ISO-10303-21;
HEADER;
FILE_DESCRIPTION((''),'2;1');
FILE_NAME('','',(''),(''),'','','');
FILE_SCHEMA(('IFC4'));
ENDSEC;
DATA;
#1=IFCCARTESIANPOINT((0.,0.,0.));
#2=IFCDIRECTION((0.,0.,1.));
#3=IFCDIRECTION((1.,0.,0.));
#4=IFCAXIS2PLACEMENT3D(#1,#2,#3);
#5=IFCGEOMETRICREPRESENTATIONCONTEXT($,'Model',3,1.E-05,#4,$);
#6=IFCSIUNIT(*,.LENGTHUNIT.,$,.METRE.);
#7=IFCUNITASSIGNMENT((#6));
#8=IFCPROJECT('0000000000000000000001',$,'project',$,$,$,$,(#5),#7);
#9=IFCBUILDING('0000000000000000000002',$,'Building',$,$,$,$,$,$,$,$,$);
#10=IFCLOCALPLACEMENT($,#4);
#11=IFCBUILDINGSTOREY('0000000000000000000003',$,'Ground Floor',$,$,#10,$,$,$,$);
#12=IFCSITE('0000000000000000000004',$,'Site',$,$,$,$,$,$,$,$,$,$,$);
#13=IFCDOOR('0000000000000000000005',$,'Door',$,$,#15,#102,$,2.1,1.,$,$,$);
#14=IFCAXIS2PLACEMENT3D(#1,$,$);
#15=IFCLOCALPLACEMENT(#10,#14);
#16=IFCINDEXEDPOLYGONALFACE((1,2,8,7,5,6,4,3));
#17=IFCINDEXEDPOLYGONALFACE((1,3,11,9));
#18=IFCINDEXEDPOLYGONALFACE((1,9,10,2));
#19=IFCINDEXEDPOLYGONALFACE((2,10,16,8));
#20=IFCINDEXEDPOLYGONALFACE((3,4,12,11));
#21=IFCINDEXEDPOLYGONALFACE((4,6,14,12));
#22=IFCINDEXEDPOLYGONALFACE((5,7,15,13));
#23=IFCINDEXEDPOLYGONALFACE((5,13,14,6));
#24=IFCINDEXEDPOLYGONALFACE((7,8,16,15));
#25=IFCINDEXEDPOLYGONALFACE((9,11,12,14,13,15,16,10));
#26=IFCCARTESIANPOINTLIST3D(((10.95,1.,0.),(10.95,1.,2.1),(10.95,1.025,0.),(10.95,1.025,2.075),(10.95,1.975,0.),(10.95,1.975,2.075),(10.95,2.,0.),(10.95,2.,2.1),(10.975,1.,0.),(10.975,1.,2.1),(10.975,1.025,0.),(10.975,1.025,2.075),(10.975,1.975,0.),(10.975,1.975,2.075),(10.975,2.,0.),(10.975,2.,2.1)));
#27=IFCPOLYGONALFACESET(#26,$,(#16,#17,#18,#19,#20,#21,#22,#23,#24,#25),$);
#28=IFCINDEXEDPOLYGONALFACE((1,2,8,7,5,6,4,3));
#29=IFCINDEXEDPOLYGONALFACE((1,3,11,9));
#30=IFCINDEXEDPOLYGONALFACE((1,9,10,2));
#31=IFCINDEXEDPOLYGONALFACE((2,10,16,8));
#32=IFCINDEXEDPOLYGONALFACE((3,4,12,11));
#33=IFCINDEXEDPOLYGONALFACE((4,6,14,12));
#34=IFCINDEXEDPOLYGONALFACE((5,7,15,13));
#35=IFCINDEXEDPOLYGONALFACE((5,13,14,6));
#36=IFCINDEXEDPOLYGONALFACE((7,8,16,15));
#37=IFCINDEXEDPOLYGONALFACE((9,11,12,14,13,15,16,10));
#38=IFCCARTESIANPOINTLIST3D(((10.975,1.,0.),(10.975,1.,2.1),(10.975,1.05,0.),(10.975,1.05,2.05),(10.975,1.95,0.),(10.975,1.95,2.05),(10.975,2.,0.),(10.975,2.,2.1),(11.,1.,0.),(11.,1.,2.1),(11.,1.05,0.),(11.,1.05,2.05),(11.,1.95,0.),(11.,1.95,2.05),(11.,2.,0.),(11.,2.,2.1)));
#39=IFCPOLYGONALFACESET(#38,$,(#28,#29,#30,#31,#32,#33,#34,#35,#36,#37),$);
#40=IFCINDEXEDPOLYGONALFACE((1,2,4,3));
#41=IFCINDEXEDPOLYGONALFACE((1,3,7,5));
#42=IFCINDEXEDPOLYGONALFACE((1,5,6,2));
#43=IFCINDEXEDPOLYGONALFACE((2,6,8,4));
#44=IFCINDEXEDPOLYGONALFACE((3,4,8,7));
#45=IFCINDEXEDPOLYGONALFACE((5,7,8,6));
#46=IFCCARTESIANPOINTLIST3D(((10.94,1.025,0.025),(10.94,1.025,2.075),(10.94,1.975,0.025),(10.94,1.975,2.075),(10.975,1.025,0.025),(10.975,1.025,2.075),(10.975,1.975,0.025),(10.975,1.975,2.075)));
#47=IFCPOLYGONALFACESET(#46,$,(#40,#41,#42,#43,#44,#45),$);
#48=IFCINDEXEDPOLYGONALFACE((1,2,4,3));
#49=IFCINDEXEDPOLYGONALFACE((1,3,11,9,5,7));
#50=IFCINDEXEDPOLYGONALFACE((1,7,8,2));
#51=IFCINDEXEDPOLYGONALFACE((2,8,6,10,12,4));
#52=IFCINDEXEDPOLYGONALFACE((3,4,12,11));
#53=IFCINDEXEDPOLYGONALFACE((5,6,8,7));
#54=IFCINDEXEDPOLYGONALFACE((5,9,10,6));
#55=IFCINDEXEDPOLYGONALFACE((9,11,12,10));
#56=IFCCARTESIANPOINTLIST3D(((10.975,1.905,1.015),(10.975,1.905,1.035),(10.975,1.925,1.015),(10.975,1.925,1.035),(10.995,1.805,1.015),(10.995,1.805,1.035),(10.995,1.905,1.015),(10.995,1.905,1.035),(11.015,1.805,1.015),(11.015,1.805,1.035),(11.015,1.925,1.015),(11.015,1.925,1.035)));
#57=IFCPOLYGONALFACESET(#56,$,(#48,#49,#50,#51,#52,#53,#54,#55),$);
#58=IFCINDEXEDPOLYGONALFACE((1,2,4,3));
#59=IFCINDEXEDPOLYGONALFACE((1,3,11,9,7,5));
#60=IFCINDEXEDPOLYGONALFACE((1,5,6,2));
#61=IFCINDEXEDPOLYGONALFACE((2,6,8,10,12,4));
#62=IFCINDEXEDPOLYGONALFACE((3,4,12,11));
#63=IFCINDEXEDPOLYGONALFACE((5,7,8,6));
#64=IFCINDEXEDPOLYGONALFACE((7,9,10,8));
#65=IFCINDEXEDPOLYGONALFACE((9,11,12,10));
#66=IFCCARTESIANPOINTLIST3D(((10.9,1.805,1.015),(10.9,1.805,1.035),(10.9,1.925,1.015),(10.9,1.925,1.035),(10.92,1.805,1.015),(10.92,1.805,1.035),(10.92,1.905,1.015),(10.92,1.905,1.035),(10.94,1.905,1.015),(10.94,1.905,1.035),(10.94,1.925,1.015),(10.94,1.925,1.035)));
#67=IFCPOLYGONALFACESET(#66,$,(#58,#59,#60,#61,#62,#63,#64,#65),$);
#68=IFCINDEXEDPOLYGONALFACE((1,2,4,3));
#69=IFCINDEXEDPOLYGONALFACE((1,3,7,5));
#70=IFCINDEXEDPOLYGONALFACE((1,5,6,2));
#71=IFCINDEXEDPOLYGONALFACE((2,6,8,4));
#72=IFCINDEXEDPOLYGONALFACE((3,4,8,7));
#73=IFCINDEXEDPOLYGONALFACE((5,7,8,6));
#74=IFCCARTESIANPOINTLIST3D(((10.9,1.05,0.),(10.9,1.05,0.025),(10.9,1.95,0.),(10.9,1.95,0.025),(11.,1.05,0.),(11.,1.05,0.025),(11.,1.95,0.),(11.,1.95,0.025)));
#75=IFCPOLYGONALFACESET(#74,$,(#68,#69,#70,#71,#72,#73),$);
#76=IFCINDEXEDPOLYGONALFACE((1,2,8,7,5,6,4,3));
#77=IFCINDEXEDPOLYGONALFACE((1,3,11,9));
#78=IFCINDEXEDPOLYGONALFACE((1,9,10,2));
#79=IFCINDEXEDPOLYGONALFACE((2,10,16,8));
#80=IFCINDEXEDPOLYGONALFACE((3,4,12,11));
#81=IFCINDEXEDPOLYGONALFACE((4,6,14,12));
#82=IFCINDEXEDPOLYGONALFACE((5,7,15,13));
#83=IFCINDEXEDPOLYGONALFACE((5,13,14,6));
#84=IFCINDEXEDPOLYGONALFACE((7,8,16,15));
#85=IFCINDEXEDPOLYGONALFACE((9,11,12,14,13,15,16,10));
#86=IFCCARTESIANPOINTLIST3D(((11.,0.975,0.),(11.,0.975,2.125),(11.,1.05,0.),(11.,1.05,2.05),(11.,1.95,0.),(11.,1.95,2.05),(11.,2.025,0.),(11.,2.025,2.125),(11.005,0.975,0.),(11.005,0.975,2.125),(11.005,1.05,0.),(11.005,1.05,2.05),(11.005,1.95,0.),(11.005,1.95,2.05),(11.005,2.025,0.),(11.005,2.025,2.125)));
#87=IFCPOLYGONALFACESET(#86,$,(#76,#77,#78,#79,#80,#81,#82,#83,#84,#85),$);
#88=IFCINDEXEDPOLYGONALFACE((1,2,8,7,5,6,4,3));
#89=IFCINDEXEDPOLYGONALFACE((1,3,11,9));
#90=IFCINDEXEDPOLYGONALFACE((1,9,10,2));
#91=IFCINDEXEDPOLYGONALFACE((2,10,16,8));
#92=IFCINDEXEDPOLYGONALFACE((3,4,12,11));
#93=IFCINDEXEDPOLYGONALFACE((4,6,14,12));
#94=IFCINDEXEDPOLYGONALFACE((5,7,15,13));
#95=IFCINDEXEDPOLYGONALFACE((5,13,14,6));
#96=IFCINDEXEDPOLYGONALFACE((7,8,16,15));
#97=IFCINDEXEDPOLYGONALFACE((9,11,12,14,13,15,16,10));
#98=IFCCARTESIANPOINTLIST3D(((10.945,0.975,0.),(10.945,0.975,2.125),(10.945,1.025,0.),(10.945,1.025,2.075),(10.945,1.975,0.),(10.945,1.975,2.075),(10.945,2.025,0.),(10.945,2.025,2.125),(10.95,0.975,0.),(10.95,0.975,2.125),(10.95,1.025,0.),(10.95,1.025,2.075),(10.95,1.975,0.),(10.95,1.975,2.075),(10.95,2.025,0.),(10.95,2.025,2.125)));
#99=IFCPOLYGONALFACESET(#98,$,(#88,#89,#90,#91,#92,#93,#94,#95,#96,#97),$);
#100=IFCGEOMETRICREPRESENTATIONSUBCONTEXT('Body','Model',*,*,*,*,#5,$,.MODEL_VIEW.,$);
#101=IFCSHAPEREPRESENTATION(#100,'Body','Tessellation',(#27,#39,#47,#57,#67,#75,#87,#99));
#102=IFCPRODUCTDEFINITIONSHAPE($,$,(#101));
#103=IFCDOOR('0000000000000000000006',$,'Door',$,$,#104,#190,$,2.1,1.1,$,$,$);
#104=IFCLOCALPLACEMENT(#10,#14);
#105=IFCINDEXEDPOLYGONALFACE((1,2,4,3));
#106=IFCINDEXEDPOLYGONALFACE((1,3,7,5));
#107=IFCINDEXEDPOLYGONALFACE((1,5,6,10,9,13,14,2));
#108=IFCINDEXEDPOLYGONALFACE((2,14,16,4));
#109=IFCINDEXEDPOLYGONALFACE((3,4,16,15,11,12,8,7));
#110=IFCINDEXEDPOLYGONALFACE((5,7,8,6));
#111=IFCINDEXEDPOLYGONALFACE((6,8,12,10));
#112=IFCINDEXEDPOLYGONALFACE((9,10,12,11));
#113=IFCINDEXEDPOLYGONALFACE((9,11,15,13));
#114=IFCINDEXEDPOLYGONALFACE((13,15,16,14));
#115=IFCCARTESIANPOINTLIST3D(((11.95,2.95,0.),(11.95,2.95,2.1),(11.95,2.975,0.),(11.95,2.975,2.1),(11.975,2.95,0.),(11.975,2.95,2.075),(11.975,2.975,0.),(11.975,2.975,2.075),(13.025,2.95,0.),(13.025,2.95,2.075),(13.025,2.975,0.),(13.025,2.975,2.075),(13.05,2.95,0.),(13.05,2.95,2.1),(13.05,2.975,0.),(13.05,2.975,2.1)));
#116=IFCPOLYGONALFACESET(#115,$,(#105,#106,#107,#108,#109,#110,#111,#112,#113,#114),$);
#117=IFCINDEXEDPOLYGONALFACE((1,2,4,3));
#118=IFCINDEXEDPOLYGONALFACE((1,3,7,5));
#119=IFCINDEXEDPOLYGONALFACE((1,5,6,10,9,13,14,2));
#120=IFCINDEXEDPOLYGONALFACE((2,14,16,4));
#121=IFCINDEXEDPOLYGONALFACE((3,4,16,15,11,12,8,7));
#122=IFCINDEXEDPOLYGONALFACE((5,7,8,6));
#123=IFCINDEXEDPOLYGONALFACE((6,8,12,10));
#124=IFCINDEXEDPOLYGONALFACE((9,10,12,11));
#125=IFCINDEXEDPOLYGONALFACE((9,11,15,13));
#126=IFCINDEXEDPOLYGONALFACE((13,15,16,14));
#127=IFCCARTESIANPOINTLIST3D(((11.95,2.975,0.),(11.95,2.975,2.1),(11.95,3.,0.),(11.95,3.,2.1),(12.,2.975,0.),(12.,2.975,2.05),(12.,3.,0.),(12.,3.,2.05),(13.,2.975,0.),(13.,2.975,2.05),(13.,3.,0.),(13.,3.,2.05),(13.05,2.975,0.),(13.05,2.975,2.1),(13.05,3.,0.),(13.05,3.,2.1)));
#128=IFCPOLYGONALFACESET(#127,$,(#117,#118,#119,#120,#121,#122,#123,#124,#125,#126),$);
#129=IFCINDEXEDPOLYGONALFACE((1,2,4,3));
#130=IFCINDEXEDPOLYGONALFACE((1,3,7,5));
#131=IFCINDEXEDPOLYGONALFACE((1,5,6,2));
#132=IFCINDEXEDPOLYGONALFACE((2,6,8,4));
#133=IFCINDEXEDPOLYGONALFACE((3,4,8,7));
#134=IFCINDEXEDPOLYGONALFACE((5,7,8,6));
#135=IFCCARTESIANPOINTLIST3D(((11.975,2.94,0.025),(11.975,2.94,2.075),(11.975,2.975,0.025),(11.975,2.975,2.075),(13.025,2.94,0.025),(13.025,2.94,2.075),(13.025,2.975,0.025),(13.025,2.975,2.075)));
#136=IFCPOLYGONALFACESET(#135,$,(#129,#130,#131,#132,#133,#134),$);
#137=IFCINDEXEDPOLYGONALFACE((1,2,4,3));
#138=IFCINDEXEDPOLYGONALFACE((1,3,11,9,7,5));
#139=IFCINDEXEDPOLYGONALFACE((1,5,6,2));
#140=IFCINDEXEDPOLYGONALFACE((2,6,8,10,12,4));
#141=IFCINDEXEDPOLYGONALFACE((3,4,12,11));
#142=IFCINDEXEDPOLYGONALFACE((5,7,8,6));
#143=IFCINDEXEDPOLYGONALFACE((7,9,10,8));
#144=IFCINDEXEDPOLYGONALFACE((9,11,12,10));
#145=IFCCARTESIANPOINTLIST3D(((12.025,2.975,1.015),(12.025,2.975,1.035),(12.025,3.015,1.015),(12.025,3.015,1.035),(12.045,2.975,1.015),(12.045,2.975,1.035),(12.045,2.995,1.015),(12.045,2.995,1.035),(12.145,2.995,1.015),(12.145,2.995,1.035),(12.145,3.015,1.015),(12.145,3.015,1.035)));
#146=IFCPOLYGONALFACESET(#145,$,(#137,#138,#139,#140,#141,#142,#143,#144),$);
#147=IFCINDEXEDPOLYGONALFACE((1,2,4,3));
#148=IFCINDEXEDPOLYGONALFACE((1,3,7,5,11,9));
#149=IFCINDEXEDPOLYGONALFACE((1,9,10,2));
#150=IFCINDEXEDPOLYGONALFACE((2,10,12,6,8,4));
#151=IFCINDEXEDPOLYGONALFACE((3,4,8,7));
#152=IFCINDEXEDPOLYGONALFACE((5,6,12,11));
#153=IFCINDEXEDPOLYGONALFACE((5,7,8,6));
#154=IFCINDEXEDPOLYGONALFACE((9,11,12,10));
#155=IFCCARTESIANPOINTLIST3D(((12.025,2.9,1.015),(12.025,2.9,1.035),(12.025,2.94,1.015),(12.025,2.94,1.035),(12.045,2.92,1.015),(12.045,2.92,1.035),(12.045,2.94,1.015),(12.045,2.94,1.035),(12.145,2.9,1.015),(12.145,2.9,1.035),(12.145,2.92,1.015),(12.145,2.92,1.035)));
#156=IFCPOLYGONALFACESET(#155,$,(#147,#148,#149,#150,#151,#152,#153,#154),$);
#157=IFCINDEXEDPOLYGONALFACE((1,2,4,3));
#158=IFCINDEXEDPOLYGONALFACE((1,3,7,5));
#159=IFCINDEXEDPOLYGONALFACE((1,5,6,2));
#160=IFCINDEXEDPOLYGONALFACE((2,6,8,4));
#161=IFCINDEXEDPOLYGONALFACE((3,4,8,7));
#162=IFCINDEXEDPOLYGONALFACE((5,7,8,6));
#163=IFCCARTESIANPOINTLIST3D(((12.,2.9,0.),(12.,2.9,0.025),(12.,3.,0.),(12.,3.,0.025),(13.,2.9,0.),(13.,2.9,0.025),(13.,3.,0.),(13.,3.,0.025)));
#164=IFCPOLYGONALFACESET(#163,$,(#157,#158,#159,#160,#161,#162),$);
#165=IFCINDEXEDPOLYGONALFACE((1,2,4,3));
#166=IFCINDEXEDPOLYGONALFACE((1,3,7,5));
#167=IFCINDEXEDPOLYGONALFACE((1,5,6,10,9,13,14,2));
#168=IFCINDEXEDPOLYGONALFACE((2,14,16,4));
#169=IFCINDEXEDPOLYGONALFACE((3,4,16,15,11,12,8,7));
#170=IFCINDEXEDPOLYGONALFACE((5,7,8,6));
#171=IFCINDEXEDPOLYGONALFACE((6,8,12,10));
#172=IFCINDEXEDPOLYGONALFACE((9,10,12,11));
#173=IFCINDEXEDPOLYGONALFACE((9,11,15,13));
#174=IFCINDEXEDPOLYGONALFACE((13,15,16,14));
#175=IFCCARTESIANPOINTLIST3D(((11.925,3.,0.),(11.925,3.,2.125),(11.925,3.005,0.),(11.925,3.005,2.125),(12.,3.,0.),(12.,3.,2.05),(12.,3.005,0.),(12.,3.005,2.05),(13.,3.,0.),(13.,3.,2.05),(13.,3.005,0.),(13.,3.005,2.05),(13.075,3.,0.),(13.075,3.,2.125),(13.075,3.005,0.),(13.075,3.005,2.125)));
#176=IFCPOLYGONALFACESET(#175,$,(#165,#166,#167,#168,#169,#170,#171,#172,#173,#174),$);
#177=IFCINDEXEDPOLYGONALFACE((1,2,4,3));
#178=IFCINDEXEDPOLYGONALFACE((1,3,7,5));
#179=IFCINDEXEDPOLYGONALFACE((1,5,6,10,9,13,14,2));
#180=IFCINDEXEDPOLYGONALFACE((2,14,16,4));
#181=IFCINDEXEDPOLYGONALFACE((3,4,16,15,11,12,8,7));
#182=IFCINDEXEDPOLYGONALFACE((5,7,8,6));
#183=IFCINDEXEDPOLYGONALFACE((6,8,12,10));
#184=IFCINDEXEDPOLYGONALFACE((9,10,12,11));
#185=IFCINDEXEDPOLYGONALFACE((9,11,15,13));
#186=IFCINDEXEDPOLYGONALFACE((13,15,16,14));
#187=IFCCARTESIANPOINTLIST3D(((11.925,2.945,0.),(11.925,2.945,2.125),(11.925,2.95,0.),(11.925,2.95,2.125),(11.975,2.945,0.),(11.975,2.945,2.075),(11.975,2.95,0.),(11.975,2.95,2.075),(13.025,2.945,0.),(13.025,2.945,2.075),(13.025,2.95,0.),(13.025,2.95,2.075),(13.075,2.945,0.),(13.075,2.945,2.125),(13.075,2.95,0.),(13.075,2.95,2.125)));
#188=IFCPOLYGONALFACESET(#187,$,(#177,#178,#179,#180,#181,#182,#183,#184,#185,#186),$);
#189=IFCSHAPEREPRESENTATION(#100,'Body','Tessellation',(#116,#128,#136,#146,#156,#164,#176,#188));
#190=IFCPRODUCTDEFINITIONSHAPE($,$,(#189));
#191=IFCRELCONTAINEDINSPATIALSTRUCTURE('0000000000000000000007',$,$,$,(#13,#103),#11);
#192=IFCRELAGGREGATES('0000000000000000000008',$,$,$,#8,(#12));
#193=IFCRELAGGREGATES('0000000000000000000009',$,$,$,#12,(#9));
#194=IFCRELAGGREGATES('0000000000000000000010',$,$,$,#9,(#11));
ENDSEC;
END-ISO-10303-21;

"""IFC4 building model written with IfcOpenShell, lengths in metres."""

from ifc_helpers import new_model, si_unit, frame, origin_with_axes, place, context, subcontext, project, spatial, line, indexed_curve, outline, extrude, element, save


model = new_model("IFC4")

# Units and contexts
model_context = context("Model", 3, precision=1e-05, world=origin_with_axes())
body_context = subcontext(model_context, "Body", "Model", "MODEL_VIEW")
ifc_project = project(units=[si_unit("LENGTHUNIT", "METRE")], contexts=[model_context])

# Site, building, storey
site = spatial("IfcSite", under=ifc_project, Name="Site")
building = spatial("IfcBuilding", under=site, Name="Building")
storey_placement = place(None, origin_with_axes())
storey = spatial("IfcBuildingStorey", under=building, at=storey_placement, Name="Ground Floor")

# Doors
door_1_placement = place(storey_placement, frame((11.0, 1.0, 0.0), z_axis=(0.0, 0.0, 1.0), x_axis=(0.0, 1.0, 0.0)))
element("IfcDoor", 1, at=door_1_placement, inside=storey, Name="Door", OverallHeight=2.1, OverallWidth=1.0, context=body_context, shape_type="SweptSolid", body=[
    extrude(outline(indexed_curve([(0.0, 0.0), (0.0, 2.1), (1.0, 2.1), (1.0, 0.0), (0.975, 0.0), (0.975, 2.075), (0.025, 2.075), (0.025, 0.0)], segments=[line(1, 2, 3, 4, 5, 6, 7, 8, 1)])), frame((0.0, 0.025, 0.0), z_axis=(0.0, -1.0, 0.0), x_axis=(1.0, 0.0, 0.0)), (0.0, 0.0, -1.0), 0.025),
    extrude(outline(indexed_curve([(0.0, 0.0), (0.0, 2.1), (1.0, 2.1), (1.0, 0.0), (0.95, 0.0), (0.95, 2.05), (0.05, 2.05), (0.05, 0.0)], segments=[line(1, 2, 3, 4, 5, 6, 7, 8, 1)])), frame((0.0, 0.0, 0.0), z_axis=(0.0, -1.0, 0.0), x_axis=(1.0, 0.0, 0.0)), (0.0, 0.0, -1.0), 0.025),
    extrude(outline(indexed_curve([(0.0, 0.0), (0.95, 0.0), (0.95, 0.035), (0.0, 0.035)], segments=[line(1, 2, 3, 4, 1)])), frame((0.025, 0.025, 0.025), z_axis=(0.0, 0.0, 1.0), x_axis=(1.0, 0.0, 0.0)), (0.0, 0.0, 1.0), 2.05),
    extrude(outline(indexed_curve([(0.0, 0.0), (0.0, -0.04), (-0.12, -0.04), (-0.12, -0.02), (-0.02, -0.02), (-0.02, 0.0)], segments=[line(1, 2, 3, 4, 5, 6, 1)])), frame((0.925, 0.025, 1.015), z_axis=(0.0, 0.0, 1.0), x_axis=(1.0, 0.0, 0.0)), (0.0, 0.0, 1.0), 0.02),
    extrude(outline(indexed_curve([(0.0, 0.0), (0.0, 0.04), (-0.12, 0.04), (-0.12, 0.02), (-0.02, 0.02), (-0.02, 0.0)], segments=[line(1, 2, 3, 4, 5, 6, 1)])), frame((0.925, 0.06, 1.015), z_axis=(0.0, 0.0, 1.0), x_axis=(1.0, 0.0, 0.0)), (0.0, 0.0, 1.0), 0.02),
    extrude(outline(indexed_curve([(0.0, 0.0), (0.9, 0.0), (0.9, 0.1), (0.0, 0.1)], segments=[line(1, 2, 3, 4, 1)])), frame((0.05, 0.0, 0.0), z_axis=(0.0, 0.0, 1.0), x_axis=(1.0, 0.0, 0.0)), (0.0, 0.0, 1.0), 0.025),
    extrude(outline(indexed_curve([(0.0, 0.0), (0.0, 2.125), (1.05, 2.125), (1.05, 0.0), (0.975, 0.0), (0.975, 2.05), (0.075, 2.05), (0.075, 0.0)], segments=[line(1, 2, 3, 4, 5, 6, 7, 8, 1)])), frame((-0.025, -0.005, 0.0), z_axis=(0.0, -1.0, 0.0), x_axis=(1.0, 0.0, 0.0)), (0.0, 0.0, -1.0), 0.005),
    extrude(outline(indexed_curve([(0.0, 0.0), (0.0, 2.125), (1.05, 2.125), (1.05, 0.0), (1.0, 0.0), (1.0, 2.075), (0.05, 2.075), (0.05, 0.0)], segments=[line(1, 2, 3, 4, 5, 6, 7, 8, 1)])), frame((-0.025, 0.05, 0.0), z_axis=(0.0, -1.0, 0.0), x_axis=(1.0, 0.0, 0.0)), (0.0, 0.0, -1.0), 0.005),
])
door_2_placement = place(storey_placement, frame((13.05, 3.0, 0.0), z_axis=(0.0, 0.0, 1.0), x_axis=(-1.0, 0.0, 0.0)))
element("IfcDoor", 2, at=door_2_placement, inside=storey, Name="Door", OverallHeight=2.1, OverallWidth=1.1, context=body_context, shape_type="SweptSolid", body=[
    extrude(outline(indexed_curve([(0.0, 0.0), (0.0, 2.1), (1.1, 2.1), (1.1, 0.0), (1.075, 0.0), (1.075, 2.075), (0.025, 2.075), (0.025, 0.0)], segments=[line(1, 2, 3, 4, 5, 6, 7, 8, 1)])), frame((0.0, 0.025, 0.0), z_axis=(0.0, -1.0, 0.0), x_axis=(1.0, 0.0, 0.0)), (0.0, 0.0, -1.0), 0.025),
    extrude(outline(indexed_curve([(0.0, 0.0), (0.0, 2.1), (1.1, 2.1), (1.1, 0.0), (1.05, 0.0), (1.05, 2.05), (0.05, 2.05), (0.05, 0.0)], segments=[line(1, 2, 3, 4, 5, 6, 7, 8, 1)])), frame((0.0, 0.0, 0.0), z_axis=(0.0, -1.0, 0.0), x_axis=(1.0, 0.0, 0.0)), (0.0, 0.0, -1.0), 0.025),
    extrude(outline(indexed_curve([(0.0, 0.0), (1.05, 0.0), (1.05, 0.035), (0.0, 0.035)], segments=[line(1, 2, 3, 4, 1)])), frame((0.025, 0.025, 0.025), z_axis=(0.0, 0.0, 1.0), x_axis=(1.0, 0.0, 0.0)), (0.0, 0.0, 1.0), 2.05),
    extrude(outline(indexed_curve([(0.0, 0.0), (0.0, -0.04), (-0.12, -0.04), (-0.12, -0.02), (-0.02, -0.02), (-0.02, 0.0)], segments=[line(1, 2, 3, 4, 5, 6, 1)])), frame((1.025, 0.025, 1.015), z_axis=(0.0, 0.0, 1.0), x_axis=(1.0, 0.0, 0.0)), (0.0, 0.0, 1.0), 0.02),
    extrude(outline(indexed_curve([(0.0, 0.0), (0.0, 0.04), (-0.12, 0.04), (-0.12, 0.02), (-0.02, 0.02), (-0.02, 0.0)], segments=[line(1, 2, 3, 4, 5, 6, 1)])), frame((1.025, 0.06, 1.015), z_axis=(0.0, 0.0, 1.0), x_axis=(1.0, 0.0, 0.0)), (0.0, 0.0, 1.0), 0.02),
    extrude(outline(indexed_curve([(0.0, 0.0), (1.0, 0.0), (1.0, 0.1), (0.0, 0.1)], segments=[line(1, 2, 3, 4, 1)])), frame((0.05, 0.0, 0.0), z_axis=(0.0, 0.0, 1.0), x_axis=(1.0, 0.0, 0.0)), (0.0, 0.0, 1.0), 0.025),
    extrude(outline(indexed_curve([(0.0, 0.0), (0.0, 2.125), (1.15, 2.125), (1.15, 0.0), (1.075, 0.0), (1.075, 2.05), (0.075, 2.05), (0.075, 0.0)], segments=[line(1, 2, 3, 4, 5, 6, 7, 8, 1)])), frame((-0.025, -0.005, 0.0), z_axis=(0.0, -1.0, 0.0), x_axis=(1.0, 0.0, 0.0)), (0.0, 0.0, -1.0), 0.005),
    extrude(outline(indexed_curve([(0.0, 0.0), (0.0, 2.125), (1.15, 2.125), (1.15, 0.0), (1.1, 0.0), (1.1, 2.075), (0.05, 2.075), (0.05, 0.0)], segments=[line(1, 2, 3, 4, 5, 6, 7, 8, 1)])), frame((-0.025, 0.05, 0.0), z_axis=(0.0, -1.0, 0.0), x_axis=(1.0, 0.0, 0.0)), (0.0, 0.0, -1.0), 0.005),
])

save(model, "model.ifc")
